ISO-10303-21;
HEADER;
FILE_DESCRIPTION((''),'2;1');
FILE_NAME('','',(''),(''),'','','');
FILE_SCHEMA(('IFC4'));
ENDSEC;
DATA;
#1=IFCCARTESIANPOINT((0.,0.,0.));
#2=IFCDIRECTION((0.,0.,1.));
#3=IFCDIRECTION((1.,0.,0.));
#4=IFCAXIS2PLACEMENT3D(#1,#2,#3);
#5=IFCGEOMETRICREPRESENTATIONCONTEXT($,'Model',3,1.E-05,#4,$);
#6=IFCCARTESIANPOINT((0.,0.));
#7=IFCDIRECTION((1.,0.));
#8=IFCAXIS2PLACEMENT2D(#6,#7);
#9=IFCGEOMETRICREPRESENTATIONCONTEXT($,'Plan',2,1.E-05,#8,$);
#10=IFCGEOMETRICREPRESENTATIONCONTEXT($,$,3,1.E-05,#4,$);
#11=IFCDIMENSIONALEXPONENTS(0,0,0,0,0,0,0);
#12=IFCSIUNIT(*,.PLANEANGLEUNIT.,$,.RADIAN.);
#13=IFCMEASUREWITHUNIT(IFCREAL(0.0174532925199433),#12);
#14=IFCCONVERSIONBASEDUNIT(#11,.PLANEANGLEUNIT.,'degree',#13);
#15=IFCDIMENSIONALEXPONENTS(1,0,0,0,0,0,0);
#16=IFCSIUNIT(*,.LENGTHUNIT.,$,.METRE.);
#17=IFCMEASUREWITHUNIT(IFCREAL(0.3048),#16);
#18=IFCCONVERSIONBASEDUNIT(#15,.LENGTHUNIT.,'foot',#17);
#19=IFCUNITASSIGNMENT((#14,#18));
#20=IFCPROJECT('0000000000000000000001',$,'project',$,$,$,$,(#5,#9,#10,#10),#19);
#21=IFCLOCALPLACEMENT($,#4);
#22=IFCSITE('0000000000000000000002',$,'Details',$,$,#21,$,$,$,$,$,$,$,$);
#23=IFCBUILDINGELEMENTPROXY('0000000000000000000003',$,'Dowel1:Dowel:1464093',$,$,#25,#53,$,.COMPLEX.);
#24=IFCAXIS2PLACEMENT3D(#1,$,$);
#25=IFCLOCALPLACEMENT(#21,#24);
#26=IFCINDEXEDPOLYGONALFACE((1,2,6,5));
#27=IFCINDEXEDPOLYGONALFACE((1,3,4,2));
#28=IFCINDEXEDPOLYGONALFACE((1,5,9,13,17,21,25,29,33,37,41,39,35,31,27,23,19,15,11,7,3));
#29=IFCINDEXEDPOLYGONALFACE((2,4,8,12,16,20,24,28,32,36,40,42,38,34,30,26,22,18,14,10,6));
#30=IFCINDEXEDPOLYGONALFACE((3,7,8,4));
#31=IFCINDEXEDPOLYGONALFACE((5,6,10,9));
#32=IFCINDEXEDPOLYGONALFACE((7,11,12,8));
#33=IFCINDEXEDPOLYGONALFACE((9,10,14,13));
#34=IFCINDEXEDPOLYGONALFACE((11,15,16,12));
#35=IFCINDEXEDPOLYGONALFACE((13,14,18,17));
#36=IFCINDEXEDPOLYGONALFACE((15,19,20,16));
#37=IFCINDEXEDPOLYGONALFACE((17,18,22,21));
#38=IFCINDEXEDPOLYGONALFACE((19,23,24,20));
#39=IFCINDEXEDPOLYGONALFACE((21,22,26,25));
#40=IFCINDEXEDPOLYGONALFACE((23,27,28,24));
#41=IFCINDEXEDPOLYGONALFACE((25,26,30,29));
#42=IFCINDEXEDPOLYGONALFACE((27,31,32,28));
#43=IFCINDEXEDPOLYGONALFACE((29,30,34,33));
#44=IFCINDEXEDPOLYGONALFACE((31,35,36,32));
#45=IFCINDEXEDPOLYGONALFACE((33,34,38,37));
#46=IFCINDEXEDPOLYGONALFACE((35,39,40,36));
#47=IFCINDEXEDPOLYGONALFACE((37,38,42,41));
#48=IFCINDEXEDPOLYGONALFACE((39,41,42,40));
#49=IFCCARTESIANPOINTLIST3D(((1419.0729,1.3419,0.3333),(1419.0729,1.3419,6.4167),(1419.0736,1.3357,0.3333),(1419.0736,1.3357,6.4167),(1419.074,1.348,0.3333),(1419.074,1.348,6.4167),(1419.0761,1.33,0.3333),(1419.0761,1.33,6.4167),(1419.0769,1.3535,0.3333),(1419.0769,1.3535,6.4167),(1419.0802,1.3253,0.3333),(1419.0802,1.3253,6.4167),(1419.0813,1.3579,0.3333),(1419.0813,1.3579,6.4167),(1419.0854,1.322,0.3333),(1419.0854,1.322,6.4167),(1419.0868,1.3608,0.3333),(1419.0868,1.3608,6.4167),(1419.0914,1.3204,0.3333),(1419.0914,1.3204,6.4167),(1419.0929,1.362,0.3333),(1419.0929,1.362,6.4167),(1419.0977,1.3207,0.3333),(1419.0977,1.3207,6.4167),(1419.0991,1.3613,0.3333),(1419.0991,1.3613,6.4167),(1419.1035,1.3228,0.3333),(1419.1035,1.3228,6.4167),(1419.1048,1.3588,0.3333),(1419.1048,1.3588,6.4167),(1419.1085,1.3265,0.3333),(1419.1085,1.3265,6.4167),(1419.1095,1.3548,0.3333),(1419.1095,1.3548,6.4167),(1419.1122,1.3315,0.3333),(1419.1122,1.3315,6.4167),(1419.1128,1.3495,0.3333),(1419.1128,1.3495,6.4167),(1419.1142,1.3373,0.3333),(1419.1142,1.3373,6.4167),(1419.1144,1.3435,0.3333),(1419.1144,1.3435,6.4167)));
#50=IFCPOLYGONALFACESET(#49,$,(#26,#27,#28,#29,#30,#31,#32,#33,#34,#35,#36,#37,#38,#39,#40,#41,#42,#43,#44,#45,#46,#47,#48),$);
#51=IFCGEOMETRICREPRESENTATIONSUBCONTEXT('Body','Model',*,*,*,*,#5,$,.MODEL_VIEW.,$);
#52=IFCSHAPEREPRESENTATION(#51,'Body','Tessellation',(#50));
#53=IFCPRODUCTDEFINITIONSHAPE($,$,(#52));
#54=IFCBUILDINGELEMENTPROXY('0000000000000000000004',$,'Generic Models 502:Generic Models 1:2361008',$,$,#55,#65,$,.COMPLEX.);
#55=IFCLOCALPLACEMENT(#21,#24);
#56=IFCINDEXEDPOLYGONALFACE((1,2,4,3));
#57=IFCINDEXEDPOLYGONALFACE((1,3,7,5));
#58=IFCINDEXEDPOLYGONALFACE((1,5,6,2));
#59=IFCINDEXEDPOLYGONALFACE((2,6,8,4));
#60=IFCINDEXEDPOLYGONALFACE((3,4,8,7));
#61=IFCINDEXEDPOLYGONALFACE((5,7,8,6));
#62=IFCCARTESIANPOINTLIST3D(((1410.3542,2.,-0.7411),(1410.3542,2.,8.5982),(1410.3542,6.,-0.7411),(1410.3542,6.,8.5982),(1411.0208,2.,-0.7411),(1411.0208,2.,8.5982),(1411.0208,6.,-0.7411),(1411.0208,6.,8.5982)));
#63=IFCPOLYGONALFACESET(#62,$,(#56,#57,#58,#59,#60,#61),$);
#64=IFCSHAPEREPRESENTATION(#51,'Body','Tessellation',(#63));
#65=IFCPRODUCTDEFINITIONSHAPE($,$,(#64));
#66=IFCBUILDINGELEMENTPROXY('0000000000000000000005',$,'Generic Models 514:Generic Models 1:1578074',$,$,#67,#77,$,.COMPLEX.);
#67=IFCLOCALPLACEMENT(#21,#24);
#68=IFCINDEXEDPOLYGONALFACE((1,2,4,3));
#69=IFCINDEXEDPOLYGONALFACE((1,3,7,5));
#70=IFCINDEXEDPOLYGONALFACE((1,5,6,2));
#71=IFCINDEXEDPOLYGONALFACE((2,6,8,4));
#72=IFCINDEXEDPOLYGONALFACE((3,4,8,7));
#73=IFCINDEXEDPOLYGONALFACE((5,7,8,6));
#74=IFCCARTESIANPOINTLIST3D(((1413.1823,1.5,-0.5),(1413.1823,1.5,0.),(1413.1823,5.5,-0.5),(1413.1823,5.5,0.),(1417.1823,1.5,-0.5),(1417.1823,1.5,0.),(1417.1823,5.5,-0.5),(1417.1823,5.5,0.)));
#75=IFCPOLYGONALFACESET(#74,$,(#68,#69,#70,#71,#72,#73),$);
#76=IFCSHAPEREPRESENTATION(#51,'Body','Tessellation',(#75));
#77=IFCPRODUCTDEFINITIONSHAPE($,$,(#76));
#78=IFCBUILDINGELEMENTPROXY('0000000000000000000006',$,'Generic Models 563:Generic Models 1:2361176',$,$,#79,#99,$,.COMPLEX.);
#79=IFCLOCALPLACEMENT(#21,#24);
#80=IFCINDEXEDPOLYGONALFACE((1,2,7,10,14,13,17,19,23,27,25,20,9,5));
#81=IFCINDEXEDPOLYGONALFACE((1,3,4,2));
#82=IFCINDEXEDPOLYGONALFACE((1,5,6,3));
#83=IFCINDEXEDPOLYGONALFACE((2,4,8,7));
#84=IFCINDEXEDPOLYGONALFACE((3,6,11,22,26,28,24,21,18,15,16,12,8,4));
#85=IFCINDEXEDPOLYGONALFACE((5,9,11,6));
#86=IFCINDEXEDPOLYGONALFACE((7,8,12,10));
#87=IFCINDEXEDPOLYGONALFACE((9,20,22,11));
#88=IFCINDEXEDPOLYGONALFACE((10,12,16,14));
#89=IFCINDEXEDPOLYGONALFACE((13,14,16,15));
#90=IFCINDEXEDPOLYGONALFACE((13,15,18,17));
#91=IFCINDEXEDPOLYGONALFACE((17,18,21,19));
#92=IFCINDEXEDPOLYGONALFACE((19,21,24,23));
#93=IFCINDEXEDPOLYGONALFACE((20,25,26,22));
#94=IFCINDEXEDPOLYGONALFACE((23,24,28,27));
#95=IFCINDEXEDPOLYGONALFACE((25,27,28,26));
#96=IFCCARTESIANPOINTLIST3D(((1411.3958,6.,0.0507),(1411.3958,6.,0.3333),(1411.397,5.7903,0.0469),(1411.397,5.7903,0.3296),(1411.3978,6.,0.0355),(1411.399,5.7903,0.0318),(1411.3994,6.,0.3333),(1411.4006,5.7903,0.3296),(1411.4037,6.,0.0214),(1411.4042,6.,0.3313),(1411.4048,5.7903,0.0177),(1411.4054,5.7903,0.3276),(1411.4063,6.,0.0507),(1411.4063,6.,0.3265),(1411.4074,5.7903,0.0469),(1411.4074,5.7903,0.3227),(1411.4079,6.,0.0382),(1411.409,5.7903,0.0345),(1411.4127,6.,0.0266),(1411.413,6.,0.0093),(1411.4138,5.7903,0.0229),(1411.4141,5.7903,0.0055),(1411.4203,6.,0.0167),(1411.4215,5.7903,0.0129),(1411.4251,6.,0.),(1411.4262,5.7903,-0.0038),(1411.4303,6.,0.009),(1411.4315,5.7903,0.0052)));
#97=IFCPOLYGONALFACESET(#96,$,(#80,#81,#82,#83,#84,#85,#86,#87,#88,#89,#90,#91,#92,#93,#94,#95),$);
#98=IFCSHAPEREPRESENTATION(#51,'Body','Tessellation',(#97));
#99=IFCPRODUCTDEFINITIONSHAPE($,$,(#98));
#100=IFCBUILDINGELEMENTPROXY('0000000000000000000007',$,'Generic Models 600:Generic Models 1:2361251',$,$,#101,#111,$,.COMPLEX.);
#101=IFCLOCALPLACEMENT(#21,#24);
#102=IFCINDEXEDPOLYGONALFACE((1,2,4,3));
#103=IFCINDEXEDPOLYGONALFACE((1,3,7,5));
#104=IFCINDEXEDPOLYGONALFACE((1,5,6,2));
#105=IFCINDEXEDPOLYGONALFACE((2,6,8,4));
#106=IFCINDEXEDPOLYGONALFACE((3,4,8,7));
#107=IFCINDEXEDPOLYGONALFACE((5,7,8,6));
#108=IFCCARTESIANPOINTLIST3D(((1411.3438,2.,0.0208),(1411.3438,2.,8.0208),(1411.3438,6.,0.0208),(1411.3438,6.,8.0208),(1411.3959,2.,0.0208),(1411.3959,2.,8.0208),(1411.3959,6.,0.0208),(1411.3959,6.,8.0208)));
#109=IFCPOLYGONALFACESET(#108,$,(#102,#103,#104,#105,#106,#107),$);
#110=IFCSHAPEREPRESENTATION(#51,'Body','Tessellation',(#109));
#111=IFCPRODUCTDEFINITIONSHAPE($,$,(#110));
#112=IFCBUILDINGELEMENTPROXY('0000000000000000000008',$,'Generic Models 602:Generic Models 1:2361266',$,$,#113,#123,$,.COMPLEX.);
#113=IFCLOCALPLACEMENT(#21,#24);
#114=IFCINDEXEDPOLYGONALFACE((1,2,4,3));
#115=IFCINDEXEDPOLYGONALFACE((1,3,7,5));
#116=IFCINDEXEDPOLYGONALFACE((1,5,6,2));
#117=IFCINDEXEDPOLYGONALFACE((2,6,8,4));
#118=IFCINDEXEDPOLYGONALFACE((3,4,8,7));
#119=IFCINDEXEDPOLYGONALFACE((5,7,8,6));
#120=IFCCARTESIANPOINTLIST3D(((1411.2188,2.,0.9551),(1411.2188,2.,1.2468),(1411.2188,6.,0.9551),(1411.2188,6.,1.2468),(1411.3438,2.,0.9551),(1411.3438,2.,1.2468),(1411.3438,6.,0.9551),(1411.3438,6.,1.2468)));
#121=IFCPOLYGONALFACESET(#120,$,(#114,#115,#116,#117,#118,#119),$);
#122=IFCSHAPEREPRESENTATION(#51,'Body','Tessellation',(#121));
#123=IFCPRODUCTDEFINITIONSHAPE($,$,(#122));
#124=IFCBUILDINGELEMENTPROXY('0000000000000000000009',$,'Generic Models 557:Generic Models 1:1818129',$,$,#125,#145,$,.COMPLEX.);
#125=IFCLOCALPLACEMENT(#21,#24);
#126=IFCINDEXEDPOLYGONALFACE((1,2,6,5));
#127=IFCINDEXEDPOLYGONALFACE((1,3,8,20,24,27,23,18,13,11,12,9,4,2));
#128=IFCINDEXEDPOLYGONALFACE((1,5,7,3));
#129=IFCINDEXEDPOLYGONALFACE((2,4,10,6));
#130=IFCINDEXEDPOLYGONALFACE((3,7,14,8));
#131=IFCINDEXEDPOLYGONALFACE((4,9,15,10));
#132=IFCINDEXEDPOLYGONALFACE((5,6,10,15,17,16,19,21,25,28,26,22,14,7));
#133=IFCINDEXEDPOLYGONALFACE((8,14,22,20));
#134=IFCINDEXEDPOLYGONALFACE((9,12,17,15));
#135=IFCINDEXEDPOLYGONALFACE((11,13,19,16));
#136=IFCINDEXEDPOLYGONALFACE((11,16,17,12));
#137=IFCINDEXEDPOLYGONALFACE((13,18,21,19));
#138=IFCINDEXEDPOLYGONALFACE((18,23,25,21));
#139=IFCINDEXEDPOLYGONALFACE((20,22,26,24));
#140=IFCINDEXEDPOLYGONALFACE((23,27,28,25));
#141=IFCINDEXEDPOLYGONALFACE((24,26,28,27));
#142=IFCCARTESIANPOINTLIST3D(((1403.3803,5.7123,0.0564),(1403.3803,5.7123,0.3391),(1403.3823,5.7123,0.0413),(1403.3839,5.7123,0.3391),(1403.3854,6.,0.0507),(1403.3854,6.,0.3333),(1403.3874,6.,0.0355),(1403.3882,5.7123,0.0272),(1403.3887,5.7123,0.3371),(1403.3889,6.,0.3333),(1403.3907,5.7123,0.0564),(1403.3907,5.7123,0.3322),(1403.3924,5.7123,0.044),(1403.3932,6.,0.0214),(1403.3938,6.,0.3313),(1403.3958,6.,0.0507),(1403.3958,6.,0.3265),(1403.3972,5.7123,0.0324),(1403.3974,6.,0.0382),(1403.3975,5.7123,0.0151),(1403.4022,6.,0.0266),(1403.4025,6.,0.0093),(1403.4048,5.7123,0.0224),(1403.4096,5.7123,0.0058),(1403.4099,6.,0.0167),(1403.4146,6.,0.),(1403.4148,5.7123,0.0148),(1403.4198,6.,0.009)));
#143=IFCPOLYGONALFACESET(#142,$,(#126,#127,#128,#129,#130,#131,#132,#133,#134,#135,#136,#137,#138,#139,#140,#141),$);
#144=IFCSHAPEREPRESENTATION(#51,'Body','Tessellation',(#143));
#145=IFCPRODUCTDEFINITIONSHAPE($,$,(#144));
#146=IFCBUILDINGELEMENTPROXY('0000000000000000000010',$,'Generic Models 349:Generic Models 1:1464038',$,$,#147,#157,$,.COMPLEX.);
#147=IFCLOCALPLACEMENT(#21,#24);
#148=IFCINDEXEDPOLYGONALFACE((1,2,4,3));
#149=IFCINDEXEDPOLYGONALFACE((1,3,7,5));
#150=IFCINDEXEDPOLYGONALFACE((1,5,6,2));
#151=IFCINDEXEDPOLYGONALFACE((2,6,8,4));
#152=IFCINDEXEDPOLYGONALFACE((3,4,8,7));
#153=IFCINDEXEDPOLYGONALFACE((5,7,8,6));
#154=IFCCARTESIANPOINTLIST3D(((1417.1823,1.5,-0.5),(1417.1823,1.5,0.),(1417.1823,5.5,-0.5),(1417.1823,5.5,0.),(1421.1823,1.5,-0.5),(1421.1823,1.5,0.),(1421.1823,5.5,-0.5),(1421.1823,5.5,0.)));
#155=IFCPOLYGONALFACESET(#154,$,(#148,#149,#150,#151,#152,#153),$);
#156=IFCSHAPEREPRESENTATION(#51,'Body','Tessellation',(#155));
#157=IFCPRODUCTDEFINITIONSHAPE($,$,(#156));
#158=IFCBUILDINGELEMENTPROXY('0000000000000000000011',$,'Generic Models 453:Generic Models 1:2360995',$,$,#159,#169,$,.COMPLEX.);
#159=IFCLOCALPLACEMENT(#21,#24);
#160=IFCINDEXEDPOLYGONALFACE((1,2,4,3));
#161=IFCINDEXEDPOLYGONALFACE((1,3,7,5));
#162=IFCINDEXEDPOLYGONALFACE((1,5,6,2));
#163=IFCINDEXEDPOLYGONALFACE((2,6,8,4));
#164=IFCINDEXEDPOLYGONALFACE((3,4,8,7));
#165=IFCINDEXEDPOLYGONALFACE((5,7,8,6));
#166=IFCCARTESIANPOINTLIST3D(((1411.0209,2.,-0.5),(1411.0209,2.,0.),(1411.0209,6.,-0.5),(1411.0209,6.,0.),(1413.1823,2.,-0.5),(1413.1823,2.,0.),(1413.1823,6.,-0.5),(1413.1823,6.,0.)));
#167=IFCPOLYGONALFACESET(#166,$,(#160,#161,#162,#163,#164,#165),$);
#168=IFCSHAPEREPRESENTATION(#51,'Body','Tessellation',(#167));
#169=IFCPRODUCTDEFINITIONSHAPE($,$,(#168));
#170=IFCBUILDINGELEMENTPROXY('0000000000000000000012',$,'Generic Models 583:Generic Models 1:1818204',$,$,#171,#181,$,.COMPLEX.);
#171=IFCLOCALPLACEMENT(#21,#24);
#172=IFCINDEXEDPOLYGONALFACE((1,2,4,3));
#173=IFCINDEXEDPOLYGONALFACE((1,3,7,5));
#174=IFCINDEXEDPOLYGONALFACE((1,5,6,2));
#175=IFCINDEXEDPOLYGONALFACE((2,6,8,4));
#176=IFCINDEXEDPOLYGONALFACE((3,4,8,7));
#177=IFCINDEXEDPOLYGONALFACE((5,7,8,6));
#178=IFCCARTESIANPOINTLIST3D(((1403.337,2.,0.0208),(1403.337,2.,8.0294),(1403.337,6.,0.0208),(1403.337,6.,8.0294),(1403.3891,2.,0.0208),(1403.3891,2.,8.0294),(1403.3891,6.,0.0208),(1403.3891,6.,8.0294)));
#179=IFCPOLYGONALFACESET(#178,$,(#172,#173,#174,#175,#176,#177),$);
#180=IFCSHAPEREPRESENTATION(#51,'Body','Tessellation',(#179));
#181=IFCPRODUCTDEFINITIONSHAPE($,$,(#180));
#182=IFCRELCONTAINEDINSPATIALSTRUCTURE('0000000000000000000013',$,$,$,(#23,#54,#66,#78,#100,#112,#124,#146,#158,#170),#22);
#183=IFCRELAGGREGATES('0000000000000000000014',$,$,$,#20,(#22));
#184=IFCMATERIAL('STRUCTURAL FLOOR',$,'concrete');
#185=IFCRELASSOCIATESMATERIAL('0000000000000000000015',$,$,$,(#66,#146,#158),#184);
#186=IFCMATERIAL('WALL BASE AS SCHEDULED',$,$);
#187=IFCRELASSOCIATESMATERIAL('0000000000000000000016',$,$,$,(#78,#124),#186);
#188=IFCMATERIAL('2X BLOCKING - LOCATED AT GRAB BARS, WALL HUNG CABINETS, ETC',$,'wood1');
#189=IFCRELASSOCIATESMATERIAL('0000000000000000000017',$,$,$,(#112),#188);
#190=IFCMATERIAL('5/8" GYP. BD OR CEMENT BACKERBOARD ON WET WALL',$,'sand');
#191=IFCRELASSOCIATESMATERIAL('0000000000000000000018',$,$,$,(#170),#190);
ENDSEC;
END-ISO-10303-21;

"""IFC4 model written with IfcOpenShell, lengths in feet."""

from ifc_helpers import new_model, entity, si_unit, converted_unit, frame, origin_with_axes, origin_2d_with_axis, place, context, subcontext, project, spatial, polyline, line, indexed_curve, circle, outline, extrude, material, element, save


model = new_model("IFC4")

# Units and contexts
model_context = context("Model", 3, precision=1e-05, world=origin_with_axes())
plan_context = context("Plan", 2, precision=1e-05, world=origin_2d_with_axis())
context_of_model = context(None, 3, precision=1e-05, world=origin_with_axes())
body_context = subcontext(model_context, "Body", "Model", "MODEL_VIEW")
ifc_project = project(units=[converted_unit("PLANEANGLEUNIT", "degree", entity("IfcReal", 0.0174532925199433), si_unit("PLANEANGLEUNIT", "RADIAN"), dimensions=[0, 0, 0, 0, 0, 0, 0]), converted_unit("LENGTHUNIT", "foot", entity("IfcReal", 0.3048), si_unit("LENGTHUNIT", "METRE"), dimensions=[1, 0, 0, 0, 0, 0, 0])], contexts=[model_context, plan_context, context_of_model, context_of_model])

# Site
site_placement = place(None, origin_with_axes())
site = spatial("IfcSite", under=ifc_project, at=site_placement, Name="Details")

# Building element proxies
proxy_1_placement = place(site_placement, frame((1419.0729, 1.3203, 0.3333), z_axis=(0.0, 0.0, 1.0), x_axis=(0.0, 1.0, 0.0)))
element("IfcBuildingElementProxy", 1, at=proxy_1_placement, inside=site, Name="Dowel1:Dowel:1464093", PredefinedType="COMPLEX", context=body_context, shape_type="SweptSolid", body=[
    extrude(circle(Radius=0.0208, at=origin_2d_with_axis()), frame((0.0208, -0.0208, 0.0), z_axis=(0.0, 0.0, -1.0), x_axis=(-0.464723, -0.885456, 0.0)), (0.0, 0.0, -1.0), 6.0833),
])
proxy_2_placement = place(site_placement, frame((1410.3542, 6.0, -0.7411), z_axis=(0.0, -1.0, 0.0), x_axis=(0.0, 0.0, 1.0)))
element("IfcBuildingElementProxy", 2, at=proxy_2_placement, inside=site, Name="Generic Models 502:Generic Models 1:2361008", PredefinedType="COMPLEX", context=body_context, shape_type="SweptSolid", body=[
    extrude(outline(indexed_curve([(-0.3333, -4.6697), (0.3333, -4.6697), (0.3333, 4.6697), (-0.3333, 4.6697)], segments=[line(4, 1), line(1, 2), line(2, 3), line(3, 4)], self_intersect=False)), frame((4.6697, -0.3333, 0.0), z_axis=(0.0, 0.0, -1.0), x_axis=(0.0, 1.0, 0.0)), (0.0, 0.0, -1.0), 4.0),
])
ifc_material_1 = material(Name="STRUCTURAL FLOOR", Category="concrete")
proxy_3_placement = place(site_placement, frame((1413.1823, 5.5, -0.5), z_axis=(0.0, -1.0, 0.0), x_axis=(0.0, 0.0, 1.0)))
element("IfcBuildingElementProxy", 3, at=proxy_3_placement, inside=site, material=ifc_material_1, Name="Generic Models 514:Generic Models 1:1578074", PredefinedType="COMPLEX", context=body_context, shape_type="SweptSolid", body=[
    extrude(outline(polyline([(-0.25, -2.0), (0.25, -2.0), (0.25, 2.0), (-0.25, 2.0), (-0.25, -2.0)])), frame((0.25, -2.0, 0.0), z_axis=(0.0, 0.0, -1.0), x_axis=(1.0, 0.0, 0.0)), (0.0, 0.0, -1.0), 4.0),
])
ifc_material_2 = material(Name="WALL BASE AS SCHEDULED")
proxy_4_placement = place(site_placement, frame((1411.3958, 6.0, 0.0), z_axis=(0.0, -1.0, 0.0), x_axis=(0.0, 0.0, 1.0)))
element("IfcBuildingElementProxy", 4, at=proxy_4_placement, inside=site, material=ifc_material_2, Name="Generic Models 563:Generic Models 1:2361176", PredefinedType="COMPLEX", context=body_context, shape_type="SweptSolid", body=[
    extrude(outline(polyline([(0.0971, 0.0), (0.1059, -0.009), (0.1142, -0.0027), (0.1035, 0.0082), (0.0904, 0.016), (0.0756, 0.02), (0.0603, 0.0202), (-0.2202, -0.0144), (-0.2197, -0.0179), (-0.2172, -0.0225), (-0.2121, -0.0239), (0.0616, 0.0098), (0.0742, 0.0097), (0.0863, 0.0064), (0.0971, 0.0)])), frame((0.113, -0.0126, 0.0), z_axis=(0.0, 0.0, -1.0), x_axis=(-0.992503, -0.12222, 0.0)), (0.01852, -0.003236, -0.999823), 0.2098),
])
proxy_5_placement = place(site_placement, frame((1411.3438, 6.0, 0.0208), z_axis=(0.0, -1.0, 0.0), x_axis=(0.0, 0.0, 1.0)))
element("IfcBuildingElementProxy", 5, at=proxy_5_placement, inside=site, Name="Generic Models 600:Generic Models 1:2361251", PredefinedType="COMPLEX", context=body_context, shape_type="SweptSolid", body=[
    extrude(outline(polyline([(-4.0, -0.026), (4.0, -0.026), (4.0, 0.026), (-4.0, 0.026), (-4.0, -0.026)])), frame((4.0, -0.026, 0.0), z_axis=(0.0, 0.0, -1.0), x_axis=(1.0, 0.0, 0.0)), (0.0, 0.0, -1.0), 4.0),
])
ifc_material_3 = material(Name="2X BLOCKING - LOCATED AT GRAB BARS, WALL HUNG CABINETS, ETC", Category="wood1")
proxy_6_placement = place(site_placement, frame((1411.2188, 6.0, 0.9551), z_axis=(0.0, -1.0, 0.0), x_axis=(0.0, 0.0, 1.0)))
element("IfcBuildingElementProxy", 6, at=proxy_6_placement, inside=site, material=ifc_material_3, Name="Generic Models 602:Generic Models 1:2361266", PredefinedType="COMPLEX", context=body_context, shape_type="SweptSolid", body=[
    extrude(outline(polyline([(-0.1458, -0.0625), (0.1458, -0.0625), (0.1458, 0.0625), (-0.1458, 0.0625), (-0.1458, -0.0625)])), frame((0.1458, -0.0625, 0.0), z_axis=(0.0, 0.0, -1.0), x_axis=(1.0, 0.0, 0.0)), (0.0, 0.0, -1.0), 4.0),
])
proxy_7_placement = place(site_placement, frame((1403.3854, 6.0, 0.0), z_axis=(0.0, -1.0, 0.0), x_axis=(0.0, 0.0, 1.0)))
element("IfcBuildingElementProxy", 7, at=proxy_7_placement, inside=site, material=ifc_material_2, Name="Generic Models 557:Generic Models 1:1818129", PredefinedType="COMPLEX", context=body_context, shape_type="SweptSolid", body=[
    extrude(outline(polyline([(0.1038, 0.0), (0.0913, 0.0088), (0.077, 0.014), (0.0618, 0.0153), (-0.2206, 0.0031), (-0.2205, -0.0005), (-0.2183, -0.0052), (-0.2133, -0.007), (0.0622, 0.0049), (0.0747, 0.0038), (0.0865, -0.0005), (0.0968, -0.0077), (0.1049, -0.0173), (0.1137, -0.0117), (0.1038, 0.0)])), frame((0.113, -0.0126, 0.0), z_axis=(0.0, 0.0, -1.0), x_axis=(-0.999059, -0.043362, 0.0)), (-0.020742, 0.016656, -0.999646), 0.2878),
])
proxy_8_placement = place(site_placement, frame((1417.1823, 5.5, -0.5), z_axis=(0.0, -1.0, 0.0), x_axis=(0.0, 0.0, 1.0)))
element("IfcBuildingElementProxy", 8, at=proxy_8_placement, inside=site, material=ifc_material_1, Name="Generic Models 349:Generic Models 1:1464038", PredefinedType="COMPLEX", context=body_context, shape_type="SweptSolid", body=[
    extrude(outline(polyline([(-0.25, -2.0), (0.25, -2.0), (0.25, 2.0), (-0.25, 2.0), (-0.25, -2.0)])), frame((0.25, -2.0, 0.0), z_axis=(0.0, 0.0, -1.0), x_axis=(1.0, 0.0, 0.0)), (0.0, 0.0, -1.0), 4.0),
])
proxy_9_placement = place(site_placement, frame((1411.0209, 6.0, -0.5), z_axis=(0.0, -1.0, 0.0), x_axis=(0.0, 0.0, 1.0)))
element("IfcBuildingElementProxy", 9, at=proxy_9_placement, inside=site, material=ifc_material_1, Name="Generic Models 453:Generic Models 1:2360995", PredefinedType="COMPLEX", context=body_context, shape_type="SweptSolid", body=[
    extrude(outline(polyline([(-0.25, -1.0807), (0.25, -1.0807), (0.25, 1.0807), (-0.25, 1.0807), (-0.25, -1.0807)])), frame((0.25, -1.0807, 0.0), z_axis=(0.0, 0.0, -1.0), x_axis=(1.0, 0.0, 0.0)), (0.0, 0.0, -1.0), 4.0),
])
ifc_material_4 = material(Name="5/8\" GYP. BD OR CEMENT BACKERBOARD ON WET WALL", Category="sand")
proxy_10_placement = place(site_placement, frame((1403.337, 6.0, 0.0208), z_axis=(0.0, -1.0, 0.0), x_axis=(0.0, 0.0, 1.0)))
element("IfcBuildingElementProxy", 10, at=proxy_10_placement, inside=site, material=ifc_material_4, Name="Generic Models 583:Generic Models 1:1818204", PredefinedType="COMPLEX", context=body_context, shape_type="SweptSolid", body=[
    extrude(outline(polyline([(-4.0043, -0.026), (4.0043, -0.026), (4.0043, 0.026), (-4.0043, 0.026), (-4.0043, -0.026)])), frame((4.0043, -0.026, 0.0), z_axis=(0.0, 0.0, -1.0), x_axis=(-1.0, 0.0, 0.0)), (0.0, 0.0, -1.0), 4.0),
])

save(model, "model.ifc")
